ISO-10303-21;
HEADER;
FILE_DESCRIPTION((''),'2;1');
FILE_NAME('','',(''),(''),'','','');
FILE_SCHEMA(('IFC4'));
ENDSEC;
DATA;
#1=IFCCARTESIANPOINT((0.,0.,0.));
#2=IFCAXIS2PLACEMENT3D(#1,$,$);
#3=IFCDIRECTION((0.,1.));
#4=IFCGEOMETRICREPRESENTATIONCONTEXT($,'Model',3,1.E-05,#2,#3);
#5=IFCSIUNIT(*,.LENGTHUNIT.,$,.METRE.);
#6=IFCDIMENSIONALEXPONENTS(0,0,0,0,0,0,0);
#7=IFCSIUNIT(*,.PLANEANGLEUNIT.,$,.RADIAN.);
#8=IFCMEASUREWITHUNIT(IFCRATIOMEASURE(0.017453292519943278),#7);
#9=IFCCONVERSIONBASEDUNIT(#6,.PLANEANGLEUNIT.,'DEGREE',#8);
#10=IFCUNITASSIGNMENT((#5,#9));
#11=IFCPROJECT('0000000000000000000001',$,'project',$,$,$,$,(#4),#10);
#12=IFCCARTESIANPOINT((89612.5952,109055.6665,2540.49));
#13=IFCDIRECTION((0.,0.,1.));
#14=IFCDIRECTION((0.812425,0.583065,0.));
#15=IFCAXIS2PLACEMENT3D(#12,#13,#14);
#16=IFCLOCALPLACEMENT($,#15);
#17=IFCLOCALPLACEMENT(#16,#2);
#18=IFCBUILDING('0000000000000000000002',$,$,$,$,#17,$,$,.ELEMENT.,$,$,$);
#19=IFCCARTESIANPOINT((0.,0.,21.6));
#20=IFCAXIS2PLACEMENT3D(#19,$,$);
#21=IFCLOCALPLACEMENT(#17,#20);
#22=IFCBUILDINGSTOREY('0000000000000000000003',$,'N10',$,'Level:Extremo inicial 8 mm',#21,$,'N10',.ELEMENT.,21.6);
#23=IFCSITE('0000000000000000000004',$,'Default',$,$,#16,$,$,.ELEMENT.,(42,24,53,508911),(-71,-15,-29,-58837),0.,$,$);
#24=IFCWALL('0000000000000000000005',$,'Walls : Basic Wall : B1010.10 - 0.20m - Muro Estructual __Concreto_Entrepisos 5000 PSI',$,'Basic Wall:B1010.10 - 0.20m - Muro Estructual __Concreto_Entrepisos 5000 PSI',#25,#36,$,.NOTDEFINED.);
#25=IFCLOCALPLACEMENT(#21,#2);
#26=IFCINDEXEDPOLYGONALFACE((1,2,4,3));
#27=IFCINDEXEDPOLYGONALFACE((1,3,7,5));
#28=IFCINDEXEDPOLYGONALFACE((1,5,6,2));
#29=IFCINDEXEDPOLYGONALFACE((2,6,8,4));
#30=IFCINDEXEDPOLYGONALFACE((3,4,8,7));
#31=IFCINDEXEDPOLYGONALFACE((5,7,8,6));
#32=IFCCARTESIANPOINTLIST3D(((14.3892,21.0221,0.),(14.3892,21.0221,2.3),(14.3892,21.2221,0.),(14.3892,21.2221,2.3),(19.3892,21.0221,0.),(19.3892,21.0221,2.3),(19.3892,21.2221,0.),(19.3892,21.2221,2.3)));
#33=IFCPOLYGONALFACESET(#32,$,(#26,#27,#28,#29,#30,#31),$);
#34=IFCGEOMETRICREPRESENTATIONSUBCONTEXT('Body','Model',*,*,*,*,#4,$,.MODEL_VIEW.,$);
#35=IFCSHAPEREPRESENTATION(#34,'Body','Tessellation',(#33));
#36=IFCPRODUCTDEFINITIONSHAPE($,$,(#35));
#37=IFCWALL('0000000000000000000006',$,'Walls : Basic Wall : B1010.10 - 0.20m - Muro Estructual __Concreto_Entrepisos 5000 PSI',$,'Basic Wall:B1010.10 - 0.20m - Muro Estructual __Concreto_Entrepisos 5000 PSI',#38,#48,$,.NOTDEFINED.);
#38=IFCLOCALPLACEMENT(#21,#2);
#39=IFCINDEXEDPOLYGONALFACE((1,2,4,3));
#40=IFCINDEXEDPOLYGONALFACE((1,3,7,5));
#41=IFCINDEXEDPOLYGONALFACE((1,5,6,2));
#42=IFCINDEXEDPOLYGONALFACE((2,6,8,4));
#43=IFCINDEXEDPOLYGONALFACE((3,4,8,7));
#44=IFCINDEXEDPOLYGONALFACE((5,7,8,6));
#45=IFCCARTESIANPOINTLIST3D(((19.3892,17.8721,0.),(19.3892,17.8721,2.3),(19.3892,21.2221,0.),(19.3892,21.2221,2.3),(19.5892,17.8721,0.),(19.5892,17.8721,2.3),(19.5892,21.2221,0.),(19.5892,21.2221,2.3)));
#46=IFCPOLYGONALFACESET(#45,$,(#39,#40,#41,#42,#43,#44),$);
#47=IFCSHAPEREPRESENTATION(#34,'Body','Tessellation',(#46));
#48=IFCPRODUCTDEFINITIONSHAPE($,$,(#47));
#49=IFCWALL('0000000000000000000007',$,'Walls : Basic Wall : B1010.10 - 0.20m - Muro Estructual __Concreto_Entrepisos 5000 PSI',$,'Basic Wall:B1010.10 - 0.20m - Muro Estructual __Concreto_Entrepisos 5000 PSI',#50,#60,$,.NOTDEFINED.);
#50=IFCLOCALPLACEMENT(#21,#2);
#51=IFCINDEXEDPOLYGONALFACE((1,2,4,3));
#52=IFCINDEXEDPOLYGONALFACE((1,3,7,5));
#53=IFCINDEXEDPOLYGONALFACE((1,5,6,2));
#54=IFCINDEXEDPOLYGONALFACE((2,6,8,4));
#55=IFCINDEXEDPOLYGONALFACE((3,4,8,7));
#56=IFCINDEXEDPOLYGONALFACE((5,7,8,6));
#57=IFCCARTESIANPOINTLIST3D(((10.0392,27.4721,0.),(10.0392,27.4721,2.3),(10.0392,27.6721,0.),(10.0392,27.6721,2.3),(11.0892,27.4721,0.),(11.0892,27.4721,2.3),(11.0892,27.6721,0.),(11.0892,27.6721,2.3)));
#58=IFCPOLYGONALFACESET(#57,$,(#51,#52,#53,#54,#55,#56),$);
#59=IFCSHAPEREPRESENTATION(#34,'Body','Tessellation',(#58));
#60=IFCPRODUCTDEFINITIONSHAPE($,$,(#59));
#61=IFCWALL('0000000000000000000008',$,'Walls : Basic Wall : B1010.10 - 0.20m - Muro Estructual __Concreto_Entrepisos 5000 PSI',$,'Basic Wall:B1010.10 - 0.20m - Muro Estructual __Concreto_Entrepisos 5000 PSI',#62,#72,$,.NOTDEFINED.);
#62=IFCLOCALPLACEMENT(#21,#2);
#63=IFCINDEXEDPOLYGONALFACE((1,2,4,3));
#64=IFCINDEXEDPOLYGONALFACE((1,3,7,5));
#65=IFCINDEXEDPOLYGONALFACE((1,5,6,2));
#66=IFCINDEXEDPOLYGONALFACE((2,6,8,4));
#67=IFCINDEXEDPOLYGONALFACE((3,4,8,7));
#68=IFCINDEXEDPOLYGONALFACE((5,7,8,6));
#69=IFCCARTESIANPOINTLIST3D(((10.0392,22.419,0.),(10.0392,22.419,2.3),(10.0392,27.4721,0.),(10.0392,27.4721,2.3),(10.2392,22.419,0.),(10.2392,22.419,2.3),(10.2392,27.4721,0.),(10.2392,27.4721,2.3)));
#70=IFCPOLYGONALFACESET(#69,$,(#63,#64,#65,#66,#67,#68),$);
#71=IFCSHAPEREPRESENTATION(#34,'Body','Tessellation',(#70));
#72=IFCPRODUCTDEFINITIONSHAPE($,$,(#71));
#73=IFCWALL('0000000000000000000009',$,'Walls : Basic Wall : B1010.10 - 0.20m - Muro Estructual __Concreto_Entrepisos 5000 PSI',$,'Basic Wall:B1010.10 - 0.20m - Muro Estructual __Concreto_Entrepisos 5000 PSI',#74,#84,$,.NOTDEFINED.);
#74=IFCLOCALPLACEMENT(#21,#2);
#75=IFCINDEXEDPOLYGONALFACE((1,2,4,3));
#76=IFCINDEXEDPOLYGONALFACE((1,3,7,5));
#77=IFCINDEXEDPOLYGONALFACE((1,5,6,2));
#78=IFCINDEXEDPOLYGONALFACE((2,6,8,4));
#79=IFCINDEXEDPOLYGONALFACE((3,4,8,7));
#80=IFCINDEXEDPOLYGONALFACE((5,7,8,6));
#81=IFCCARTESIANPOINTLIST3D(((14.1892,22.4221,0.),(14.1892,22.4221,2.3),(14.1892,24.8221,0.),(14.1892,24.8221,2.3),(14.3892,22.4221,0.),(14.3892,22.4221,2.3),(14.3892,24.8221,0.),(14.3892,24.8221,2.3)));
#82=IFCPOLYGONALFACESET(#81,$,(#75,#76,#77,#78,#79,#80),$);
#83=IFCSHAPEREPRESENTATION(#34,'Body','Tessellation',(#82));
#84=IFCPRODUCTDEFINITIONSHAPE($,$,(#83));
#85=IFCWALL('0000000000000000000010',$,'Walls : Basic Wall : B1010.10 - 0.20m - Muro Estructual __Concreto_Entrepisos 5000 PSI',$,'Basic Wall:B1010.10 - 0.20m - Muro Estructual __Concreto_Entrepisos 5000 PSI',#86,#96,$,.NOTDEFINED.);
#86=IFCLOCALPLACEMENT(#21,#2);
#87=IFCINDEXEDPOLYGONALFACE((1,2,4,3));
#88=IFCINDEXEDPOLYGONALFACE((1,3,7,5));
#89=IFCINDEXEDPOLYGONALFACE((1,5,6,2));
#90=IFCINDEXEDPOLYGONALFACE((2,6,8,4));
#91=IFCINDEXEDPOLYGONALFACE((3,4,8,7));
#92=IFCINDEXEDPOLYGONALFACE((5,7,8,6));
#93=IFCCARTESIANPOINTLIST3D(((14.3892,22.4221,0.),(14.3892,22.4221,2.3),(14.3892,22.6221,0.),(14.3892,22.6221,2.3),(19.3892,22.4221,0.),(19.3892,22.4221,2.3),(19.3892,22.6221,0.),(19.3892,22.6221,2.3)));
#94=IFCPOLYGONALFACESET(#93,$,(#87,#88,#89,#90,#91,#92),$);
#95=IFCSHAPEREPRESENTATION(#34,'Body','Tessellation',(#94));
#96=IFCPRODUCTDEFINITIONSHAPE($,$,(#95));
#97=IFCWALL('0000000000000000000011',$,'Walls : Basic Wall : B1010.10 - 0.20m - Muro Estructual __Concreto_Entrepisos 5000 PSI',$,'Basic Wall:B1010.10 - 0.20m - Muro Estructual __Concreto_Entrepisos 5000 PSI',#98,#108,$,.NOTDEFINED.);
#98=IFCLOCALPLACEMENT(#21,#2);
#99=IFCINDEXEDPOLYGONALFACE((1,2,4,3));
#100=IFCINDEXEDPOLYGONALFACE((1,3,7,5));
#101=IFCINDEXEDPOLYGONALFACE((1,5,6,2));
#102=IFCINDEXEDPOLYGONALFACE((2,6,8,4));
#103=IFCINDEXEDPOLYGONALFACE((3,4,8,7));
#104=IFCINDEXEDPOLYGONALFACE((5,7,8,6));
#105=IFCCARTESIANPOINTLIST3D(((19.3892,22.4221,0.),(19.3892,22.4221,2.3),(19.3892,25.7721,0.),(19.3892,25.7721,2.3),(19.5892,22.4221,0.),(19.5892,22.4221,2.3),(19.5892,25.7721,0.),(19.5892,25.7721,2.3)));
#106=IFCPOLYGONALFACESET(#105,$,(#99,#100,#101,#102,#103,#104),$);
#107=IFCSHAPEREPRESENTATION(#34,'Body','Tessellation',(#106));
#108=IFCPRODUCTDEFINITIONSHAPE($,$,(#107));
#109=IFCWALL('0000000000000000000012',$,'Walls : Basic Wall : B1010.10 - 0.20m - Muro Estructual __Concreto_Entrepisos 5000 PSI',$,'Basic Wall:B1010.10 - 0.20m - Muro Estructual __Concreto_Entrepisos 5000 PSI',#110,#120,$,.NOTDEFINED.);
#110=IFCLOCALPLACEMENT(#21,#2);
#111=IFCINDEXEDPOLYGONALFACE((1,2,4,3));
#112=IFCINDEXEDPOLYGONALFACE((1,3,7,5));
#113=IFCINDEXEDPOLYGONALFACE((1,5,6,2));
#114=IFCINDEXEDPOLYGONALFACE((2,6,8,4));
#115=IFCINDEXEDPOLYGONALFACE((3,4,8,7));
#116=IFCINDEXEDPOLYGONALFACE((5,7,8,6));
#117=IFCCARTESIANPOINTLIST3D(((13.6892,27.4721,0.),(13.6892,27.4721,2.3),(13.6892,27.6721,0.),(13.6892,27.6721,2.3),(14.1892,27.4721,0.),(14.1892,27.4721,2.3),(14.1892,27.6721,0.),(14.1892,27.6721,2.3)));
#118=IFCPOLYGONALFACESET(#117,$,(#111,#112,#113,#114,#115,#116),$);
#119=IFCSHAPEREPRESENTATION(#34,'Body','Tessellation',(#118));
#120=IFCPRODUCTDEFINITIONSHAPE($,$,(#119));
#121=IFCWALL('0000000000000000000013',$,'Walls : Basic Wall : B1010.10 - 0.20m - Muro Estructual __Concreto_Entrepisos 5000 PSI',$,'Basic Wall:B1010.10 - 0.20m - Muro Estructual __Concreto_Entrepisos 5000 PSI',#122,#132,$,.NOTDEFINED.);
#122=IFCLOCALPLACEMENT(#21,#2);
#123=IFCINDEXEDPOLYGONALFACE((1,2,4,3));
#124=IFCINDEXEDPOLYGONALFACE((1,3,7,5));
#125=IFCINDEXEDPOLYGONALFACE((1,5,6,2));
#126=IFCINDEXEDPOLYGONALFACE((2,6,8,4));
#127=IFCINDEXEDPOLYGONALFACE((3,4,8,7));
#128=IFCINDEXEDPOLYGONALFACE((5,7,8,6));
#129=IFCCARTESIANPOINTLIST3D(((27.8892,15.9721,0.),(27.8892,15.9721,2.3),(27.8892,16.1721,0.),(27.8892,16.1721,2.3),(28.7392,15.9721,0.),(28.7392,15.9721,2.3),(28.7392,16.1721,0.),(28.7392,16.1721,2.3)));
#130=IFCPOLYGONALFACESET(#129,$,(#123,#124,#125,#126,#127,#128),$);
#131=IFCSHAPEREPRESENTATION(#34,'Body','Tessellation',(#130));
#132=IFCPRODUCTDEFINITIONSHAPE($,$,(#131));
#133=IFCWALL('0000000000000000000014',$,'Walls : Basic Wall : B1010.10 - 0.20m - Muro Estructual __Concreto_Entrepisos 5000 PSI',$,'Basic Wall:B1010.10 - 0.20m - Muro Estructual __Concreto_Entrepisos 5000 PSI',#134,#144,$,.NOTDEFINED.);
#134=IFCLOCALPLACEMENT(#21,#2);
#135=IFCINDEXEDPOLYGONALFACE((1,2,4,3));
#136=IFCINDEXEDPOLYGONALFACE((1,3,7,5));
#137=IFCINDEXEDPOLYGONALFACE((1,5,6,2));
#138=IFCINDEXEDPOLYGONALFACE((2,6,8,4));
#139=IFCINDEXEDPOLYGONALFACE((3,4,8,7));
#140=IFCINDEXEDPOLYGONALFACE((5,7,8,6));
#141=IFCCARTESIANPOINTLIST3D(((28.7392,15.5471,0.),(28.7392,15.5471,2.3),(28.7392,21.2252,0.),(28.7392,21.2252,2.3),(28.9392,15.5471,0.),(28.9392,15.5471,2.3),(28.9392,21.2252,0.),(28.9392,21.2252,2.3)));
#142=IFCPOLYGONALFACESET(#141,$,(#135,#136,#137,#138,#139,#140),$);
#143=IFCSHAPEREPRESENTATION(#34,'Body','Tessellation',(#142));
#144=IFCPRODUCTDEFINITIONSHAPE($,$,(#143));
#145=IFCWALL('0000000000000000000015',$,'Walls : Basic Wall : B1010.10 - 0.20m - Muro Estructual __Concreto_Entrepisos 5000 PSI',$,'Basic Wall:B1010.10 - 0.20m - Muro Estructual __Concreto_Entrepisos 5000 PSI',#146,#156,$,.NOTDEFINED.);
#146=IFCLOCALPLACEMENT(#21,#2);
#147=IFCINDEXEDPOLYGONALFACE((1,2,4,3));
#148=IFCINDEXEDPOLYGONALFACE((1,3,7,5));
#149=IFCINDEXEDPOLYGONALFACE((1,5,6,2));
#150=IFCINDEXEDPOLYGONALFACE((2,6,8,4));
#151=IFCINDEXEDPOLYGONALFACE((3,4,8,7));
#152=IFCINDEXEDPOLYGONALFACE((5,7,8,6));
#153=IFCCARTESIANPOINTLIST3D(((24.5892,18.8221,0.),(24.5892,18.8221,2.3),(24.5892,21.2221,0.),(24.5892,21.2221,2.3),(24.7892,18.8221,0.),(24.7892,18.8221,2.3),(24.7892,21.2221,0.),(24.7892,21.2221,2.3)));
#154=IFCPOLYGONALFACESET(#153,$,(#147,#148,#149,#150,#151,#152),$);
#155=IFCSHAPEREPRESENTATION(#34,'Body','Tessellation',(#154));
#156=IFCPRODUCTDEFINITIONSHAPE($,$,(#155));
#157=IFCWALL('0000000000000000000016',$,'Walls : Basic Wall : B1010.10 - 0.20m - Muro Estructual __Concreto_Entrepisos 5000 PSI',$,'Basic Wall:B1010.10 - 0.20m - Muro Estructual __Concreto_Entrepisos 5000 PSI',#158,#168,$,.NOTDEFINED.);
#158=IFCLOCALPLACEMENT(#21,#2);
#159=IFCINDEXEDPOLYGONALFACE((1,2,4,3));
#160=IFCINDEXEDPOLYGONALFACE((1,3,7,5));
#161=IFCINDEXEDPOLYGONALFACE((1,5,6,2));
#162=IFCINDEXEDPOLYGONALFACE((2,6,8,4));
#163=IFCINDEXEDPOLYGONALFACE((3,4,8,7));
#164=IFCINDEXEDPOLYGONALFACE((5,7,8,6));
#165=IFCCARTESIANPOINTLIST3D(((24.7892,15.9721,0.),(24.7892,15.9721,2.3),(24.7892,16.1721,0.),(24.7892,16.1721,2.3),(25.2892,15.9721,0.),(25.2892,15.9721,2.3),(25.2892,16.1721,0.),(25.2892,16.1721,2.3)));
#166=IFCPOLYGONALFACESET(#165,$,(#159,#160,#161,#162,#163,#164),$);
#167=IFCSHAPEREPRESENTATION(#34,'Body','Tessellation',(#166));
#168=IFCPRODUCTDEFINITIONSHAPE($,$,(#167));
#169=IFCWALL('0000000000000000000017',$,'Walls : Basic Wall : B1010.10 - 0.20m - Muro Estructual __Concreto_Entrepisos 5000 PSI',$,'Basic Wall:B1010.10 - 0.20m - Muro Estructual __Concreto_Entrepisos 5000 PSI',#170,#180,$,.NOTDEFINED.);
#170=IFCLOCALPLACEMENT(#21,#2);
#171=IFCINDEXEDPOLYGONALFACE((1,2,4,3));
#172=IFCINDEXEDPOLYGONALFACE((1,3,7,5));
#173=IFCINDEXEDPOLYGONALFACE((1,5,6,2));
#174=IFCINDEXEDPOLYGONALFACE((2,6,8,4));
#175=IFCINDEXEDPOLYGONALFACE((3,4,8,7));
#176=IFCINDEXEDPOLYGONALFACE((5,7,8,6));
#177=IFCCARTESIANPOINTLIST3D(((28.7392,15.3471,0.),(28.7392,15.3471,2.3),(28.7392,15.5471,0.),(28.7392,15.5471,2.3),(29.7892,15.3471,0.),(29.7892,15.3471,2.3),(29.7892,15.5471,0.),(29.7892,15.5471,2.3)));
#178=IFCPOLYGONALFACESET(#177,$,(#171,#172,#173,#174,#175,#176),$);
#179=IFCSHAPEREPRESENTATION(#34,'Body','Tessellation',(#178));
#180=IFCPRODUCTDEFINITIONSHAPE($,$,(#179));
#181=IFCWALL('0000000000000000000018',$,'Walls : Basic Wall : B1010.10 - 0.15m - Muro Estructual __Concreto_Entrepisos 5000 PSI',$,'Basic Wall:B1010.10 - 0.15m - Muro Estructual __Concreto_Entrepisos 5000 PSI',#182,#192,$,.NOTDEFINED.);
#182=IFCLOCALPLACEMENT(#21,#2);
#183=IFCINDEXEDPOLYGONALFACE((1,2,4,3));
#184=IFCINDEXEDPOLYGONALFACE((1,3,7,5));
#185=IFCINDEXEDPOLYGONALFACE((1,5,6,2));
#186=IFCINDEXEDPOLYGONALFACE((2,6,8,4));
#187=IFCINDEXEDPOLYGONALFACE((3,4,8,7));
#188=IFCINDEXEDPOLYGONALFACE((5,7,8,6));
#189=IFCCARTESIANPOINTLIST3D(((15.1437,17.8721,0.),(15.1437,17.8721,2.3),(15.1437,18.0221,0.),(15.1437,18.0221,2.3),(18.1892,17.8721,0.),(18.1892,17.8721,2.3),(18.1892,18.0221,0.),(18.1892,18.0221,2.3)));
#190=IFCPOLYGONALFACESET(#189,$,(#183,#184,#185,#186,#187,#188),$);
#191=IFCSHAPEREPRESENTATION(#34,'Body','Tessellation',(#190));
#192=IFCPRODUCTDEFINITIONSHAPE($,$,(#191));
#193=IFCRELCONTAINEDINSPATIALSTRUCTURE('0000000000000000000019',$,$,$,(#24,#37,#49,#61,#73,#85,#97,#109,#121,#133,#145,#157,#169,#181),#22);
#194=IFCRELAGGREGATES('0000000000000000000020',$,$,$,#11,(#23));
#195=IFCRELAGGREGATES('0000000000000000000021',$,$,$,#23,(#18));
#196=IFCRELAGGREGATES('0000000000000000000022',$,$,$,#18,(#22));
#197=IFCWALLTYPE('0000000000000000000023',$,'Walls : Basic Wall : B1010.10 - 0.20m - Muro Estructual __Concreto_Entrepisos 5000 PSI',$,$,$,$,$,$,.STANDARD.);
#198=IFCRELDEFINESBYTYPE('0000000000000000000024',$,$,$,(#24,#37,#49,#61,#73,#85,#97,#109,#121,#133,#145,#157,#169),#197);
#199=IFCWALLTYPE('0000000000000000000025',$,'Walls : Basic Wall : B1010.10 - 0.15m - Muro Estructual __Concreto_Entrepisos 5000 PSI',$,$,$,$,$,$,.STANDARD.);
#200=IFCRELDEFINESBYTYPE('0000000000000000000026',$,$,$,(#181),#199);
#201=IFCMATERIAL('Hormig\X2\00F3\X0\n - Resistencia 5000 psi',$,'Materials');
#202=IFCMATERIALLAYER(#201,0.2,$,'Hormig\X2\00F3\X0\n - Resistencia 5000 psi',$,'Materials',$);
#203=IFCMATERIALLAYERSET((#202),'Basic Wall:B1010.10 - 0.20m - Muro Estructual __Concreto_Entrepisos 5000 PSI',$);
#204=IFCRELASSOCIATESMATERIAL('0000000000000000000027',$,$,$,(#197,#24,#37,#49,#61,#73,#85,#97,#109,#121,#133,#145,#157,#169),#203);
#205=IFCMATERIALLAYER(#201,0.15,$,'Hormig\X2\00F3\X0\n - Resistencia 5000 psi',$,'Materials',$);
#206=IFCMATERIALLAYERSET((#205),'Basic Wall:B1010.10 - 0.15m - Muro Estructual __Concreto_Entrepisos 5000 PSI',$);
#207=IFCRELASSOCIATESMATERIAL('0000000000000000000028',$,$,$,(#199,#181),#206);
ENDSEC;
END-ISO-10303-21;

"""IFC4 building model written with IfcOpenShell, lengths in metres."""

from ifc_helpers import new_model, entity, si_unit, converted_unit, direction, frame, frame_2d, origin, place, context, subcontext, project, spatial, rectangle, extrude, material, layer, layer_set, layer_usage, type_object, element, save


model = new_model("IFC4")

# Units and contexts
model_context = context("Model", 3, precision=1e-05, world=origin(), true_north=direction((0.0, 1.0)))
body_context = subcontext(model_context, "Body", "Model", "MODEL_VIEW")
ifc_project = project(units=[si_unit("LENGTHUNIT", "METRE"), converted_unit("PLANEANGLEUNIT", "DEGREE", entity("IfcRatioMeasure", 0.017453292519943278), si_unit("PLANEANGLEUNIT", "RADIAN"), dimensions=[0, 0, 0, 0, 0, 0, 0])], contexts=[model_context])

# Site, building, storey
site_placement = place(None, frame((89612.5952, 109055.6665, 2540.49), z_axis=(0.0, 0.0, 1.0), x_axis=(0.812425, 0.583065, 0.0)))
site = spatial("IfcSite", under=ifc_project, at=site_placement, Name="Default", CompositionType="ELEMENT", RefLatitude=(42, 24, 53, 508911), RefLongitude=(-71, -15, -29, -58837), RefElevation=0.0)
building_placement = place(site_placement, origin())
building = spatial("IfcBuilding", under=site, at=building_placement, CompositionType="ELEMENT")
storey_placement = place(building_placement, frame((0.0, 0.0, 21.6)))
storey = spatial("IfcBuildingStorey", under=building, at=storey_placement, Name="N10", ObjectType="Level:Extremo inicial 8 mm", LongName="N10", CompositionType="ELEMENT", Elevation=21.6)

# Walls
ifc_material = material(Name="Hormigón - Resistencia 5000 psi", Category="Materials")
ifc_layer_1 = layer(ifc_material, 0.2, Name="Hormigón - Resistencia 5000 psi", Category="Materials")
ifc_layer_set_1 = layer_set([ifc_layer_1], Name="Basic Wall:B1010.10 - 0.20m - Muro Estructual __Concreto_Entrepisos 5000 PSI")
ifc_layer_usage_1 = layer_usage(ifc_layer_set_1, "AXIS2", "NEGATIVE", 0.1)
wall_type_1 = type_object("IfcWallType", Name="Walls : Basic Wall : B1010.10 - 0.20m - Muro Estructual __Concreto_Entrepisos 5000 PSI", PredefinedType="STANDARD", material=ifc_layer_set_1)
wall_1_placement = place(storey_placement, frame((14.3892, 21.1221, 0.0)))
element("IfcWall", 1, at=wall_1_placement, inside=storey, type_object=wall_type_1, material=ifc_layer_usage_1, Name="Walls : Basic Wall : B1010.10 - 0.20m - Muro Estructual __Concreto_Entrepisos 5000 PSI", ObjectType="Basic Wall:B1010.10 - 0.20m - Muro Estructual __Concreto_Entrepisos 5000 PSI", PredefinedType="NOTDEFINED", context=body_context, shape_type="SweptSolid", body=[
    extrude(rectangle(XDim=5.0, YDim=0.2, at=frame_2d((2.5, 0.0), x_axis=(-1.0, 0.0))), origin(), (0.0, 0.0, 1.0), 2.3),
])
ifc_layer_usage_2 = layer_usage(ifc_layer_set_1, "AXIS2", "NEGATIVE", 0.1)
wall_2_placement = place(storey_placement, frame((19.4892, 21.2221, 0.0), z_axis=(0.0, 0.0, 1.0), x_axis=(0.0, -1.0, 0.0)))
element("IfcWall", 2, at=wall_2_placement, inside=storey, type_object=wall_type_1, material=ifc_layer_usage_2, Name="Walls : Basic Wall : B1010.10 - 0.20m - Muro Estructual __Concreto_Entrepisos 5000 PSI", ObjectType="Basic Wall:B1010.10 - 0.20m - Muro Estructual __Concreto_Entrepisos 5000 PSI", PredefinedType="NOTDEFINED", context=body_context, shape_type="SweptSolid", body=[
    extrude(rectangle(XDim=3.35, YDim=0.2, at=frame_2d((1.675, 0.0), x_axis=(-1.0, 0.0))), origin(), (0.0, 0.0, 1.0), 2.3),
])
ifc_layer_usage_3 = layer_usage(ifc_layer_set_1, "AXIS2", "POSITIVE", -0.1)
wall_3_placement = place(storey_placement, frame((11.0892, 27.5721, 0.0), z_axis=(0.0, 0.0, 1.0), x_axis=(-1.0, 0.0, 0.0)))
element("IfcWall", 3, at=wall_3_placement, inside=storey, type_object=wall_type_1, material=ifc_layer_usage_3, Name="Walls : Basic Wall : B1010.10 - 0.20m - Muro Estructual __Concreto_Entrepisos 5000 PSI", ObjectType="Basic Wall:B1010.10 - 0.20m - Muro Estructual __Concreto_Entrepisos 5000 PSI", PredefinedType="NOTDEFINED", context=body_context, shape_type="SweptSolid", body=[
    extrude(rectangle(XDim=1.05, YDim=0.2, at=frame_2d((0.525, 0.0), x_axis=(-1.0, 0.0))), origin(), (0.0, 0.0, 1.0), 2.3),
])
ifc_layer_usage_4 = layer_usage(ifc_layer_set_1, "AXIS2", "POSITIVE", -0.1)
wall_4_placement = place(storey_placement, frame((10.1392, 27.4721, 0.0), z_axis=(0.0, 0.0, 1.0), x_axis=(0.0, -1.0, 0.0)))
element("IfcWall", 4, at=wall_4_placement, inside=storey, type_object=wall_type_1, material=ifc_layer_usage_4, Name="Walls : Basic Wall : B1010.10 - 0.20m - Muro Estructual __Concreto_Entrepisos 5000 PSI", ObjectType="Basic Wall:B1010.10 - 0.20m - Muro Estructual __Concreto_Entrepisos 5000 PSI", PredefinedType="NOTDEFINED", context=body_context, shape_type="SweptSolid", body=[
    extrude(rectangle(XDim=5.0531, YDim=0.2, at=frame_2d((2.5265, 0.0), x_axis=(-1.0, 0.0))), origin(), (0.0, 0.0, 1.0), 2.3),
])
ifc_layer_usage_5 = layer_usage(ifc_layer_set_1, "AXIS2", "POSITIVE", -0.1)
wall_5_placement = place(storey_placement, frame((14.2892, 24.8221, 0.0), z_axis=(0.0, 0.0, 1.0), x_axis=(0.0, -1.0, 0.0)))
element("IfcWall", 5, at=wall_5_placement, inside=storey, type_object=wall_type_1, material=ifc_layer_usage_5, Name="Walls : Basic Wall : B1010.10 - 0.20m - Muro Estructual __Concreto_Entrepisos 5000 PSI", ObjectType="Basic Wall:B1010.10 - 0.20m - Muro Estructual __Concreto_Entrepisos 5000 PSI", PredefinedType="NOTDEFINED", context=body_context, shape_type="SweptSolid", body=[
    extrude(rectangle(XDim=2.4, YDim=0.2, at=frame_2d((1.2, 0.0), x_axis=(-1.0, 0.0))), origin(), (0.0, 0.0, 1.0), 2.3),
])
ifc_layer_usage_6 = layer_usage(ifc_layer_set_1, "AXIS2", "POSITIVE", -0.1)
wall_6_placement = place(storey_placement, frame((14.3892, 22.5221, 0.0)))
element("IfcWall", 6, at=wall_6_placement, inside=storey, type_object=wall_type_1, material=ifc_layer_usage_6, Name="Walls : Basic Wall : B1010.10 - 0.20m - Muro Estructual __Concreto_Entrepisos 5000 PSI", ObjectType="Basic Wall:B1010.10 - 0.20m - Muro Estructual __Concreto_Entrepisos 5000 PSI", PredefinedType="NOTDEFINED", context=body_context, shape_type="SweptSolid", body=[
    extrude(rectangle(XDim=5.0, YDim=0.2, at=frame_2d((2.5, 0.0), x_axis=(-1.0, 0.0))), origin(), (0.0, 0.0, 1.0), 2.3),
])
ifc_layer_usage_7 = layer_usage(ifc_layer_set_1, "AXIS2", "POSITIVE", -0.1)
wall_7_placement = place(storey_placement, frame((19.4892, 22.4221, 0.0), z_axis=(0.0, 0.0, 1.0), x_axis=(0.0, 1.0, 0.0)))
element("IfcWall", 7, at=wall_7_placement, inside=storey, type_object=wall_type_1, material=ifc_layer_usage_7, Name="Walls : Basic Wall : B1010.10 - 0.20m - Muro Estructual __Concreto_Entrepisos 5000 PSI", ObjectType="Basic Wall:B1010.10 - 0.20m - Muro Estructual __Concreto_Entrepisos 5000 PSI", PredefinedType="NOTDEFINED", context=body_context, shape_type="SweptSolid", body=[
    extrude(rectangle(XDim=3.35, YDim=0.2, at=frame_2d((1.675, 0.0), x_axis=(-1.0, 0.0))), origin(), (0.0, 0.0, 1.0), 2.3),
])
ifc_layer_usage_8 = layer_usage(ifc_layer_set_1, "AXIS2", "POSITIVE", -0.1)
wall_8_placement = place(storey_placement, frame((13.6892, 27.5721, 0.0)))
element("IfcWall", 8, at=wall_8_placement, inside=storey, type_object=wall_type_1, material=ifc_layer_usage_8, Name="Walls : Basic Wall : B1010.10 - 0.20m - Muro Estructual __Concreto_Entrepisos 5000 PSI", ObjectType="Basic Wall:B1010.10 - 0.20m - Muro Estructual __Concreto_Entrepisos 5000 PSI", PredefinedType="NOTDEFINED", context=body_context, shape_type="SweptSolid", body=[
    extrude(rectangle(XDim=0.5, YDim=0.2, at=frame_2d((0.25, 0.0), x_axis=(-1.0, 0.0))), origin(), (0.0, 0.0, 1.0), 2.3),
])
ifc_layer_usage_9 = layer_usage(ifc_layer_set_1, "AXIS2", "POSITIVE", -0.1)
wall_9_placement = place(storey_placement, frame((27.8892, 16.0721, 0.0)))
element("IfcWall", 9, at=wall_9_placement, inside=storey, type_object=wall_type_1, material=ifc_layer_usage_9, Name="Walls : Basic Wall : B1010.10 - 0.20m - Muro Estructual __Concreto_Entrepisos 5000 PSI", ObjectType="Basic Wall:B1010.10 - 0.20m - Muro Estructual __Concreto_Entrepisos 5000 PSI", PredefinedType="NOTDEFINED", context=body_context, shape_type="SweptSolid", body=[
    extrude(rectangle(XDim=0.85, YDim=0.2, at=frame_2d((0.425, 0.0), x_axis=(-1.0, 0.0))), origin(), (0.0, 0.0, 1.0), 2.3),
])
ifc_layer_usage_10 = layer_usage(ifc_layer_set_1, "AXIS2", "POSITIVE", -0.1)
wall_10_placement = place(storey_placement, frame((28.8392, 15.5471, 0.0), z_axis=(0.0, 0.0, 1.0), x_axis=(0.0, 1.0, 0.0)))
element("IfcWall", 10, at=wall_10_placement, inside=storey, type_object=wall_type_1, material=ifc_layer_usage_10, Name="Walls : Basic Wall : B1010.10 - 0.20m - Muro Estructual __Concreto_Entrepisos 5000 PSI", ObjectType="Basic Wall:B1010.10 - 0.20m - Muro Estructual __Concreto_Entrepisos 5000 PSI", PredefinedType="NOTDEFINED", context=body_context, shape_type="SweptSolid", body=[
    extrude(rectangle(XDim=5.6781, YDim=0.2, at=frame_2d((2.839, 0.0), x_axis=(-1.0, 0.0))), origin(), (0.0, 0.0, 1.0), 2.3),
])
ifc_layer_usage_11 = layer_usage(ifc_layer_set_1, "AXIS2", "POSITIVE", -0.1)
wall_11_placement = place(storey_placement, frame((24.6892, 18.8221, 0.0), z_axis=(0.0, 0.0, 1.0), x_axis=(0.0, 1.0, 0.0)))
element("IfcWall", 11, at=wall_11_placement, inside=storey, type_object=wall_type_1, material=ifc_layer_usage_11, Name="Walls : Basic Wall : B1010.10 - 0.20m - Muro Estructual __Concreto_Entrepisos 5000 PSI", ObjectType="Basic Wall:B1010.10 - 0.20m - Muro Estructual __Concreto_Entrepisos 5000 PSI", PredefinedType="NOTDEFINED", context=body_context, shape_type="SweptSolid", body=[
    extrude(rectangle(XDim=2.4, YDim=0.2, at=frame_2d((1.2, 0.0), x_axis=(-1.0, 0.0))), origin(), (0.0, 0.0, 1.0), 2.3),
])
ifc_layer_usage_12 = layer_usage(ifc_layer_set_1, "AXIS2", "POSITIVE", -0.1)
wall_12_placement = place(storey_placement, frame((25.2892, 16.0721, 0.0), z_axis=(0.0, 0.0, 1.0), x_axis=(-1.0, 0.0, 0.0)))
element("IfcWall", 12, at=wall_12_placement, inside=storey, type_object=wall_type_1, material=ifc_layer_usage_12, Name="Walls : Basic Wall : B1010.10 - 0.20m - Muro Estructual __Concreto_Entrepisos 5000 PSI", ObjectType="Basic Wall:B1010.10 - 0.20m - Muro Estructual __Concreto_Entrepisos 5000 PSI", PredefinedType="NOTDEFINED", context=body_context, shape_type="SweptSolid", body=[
    extrude(rectangle(XDim=0.5, YDim=0.2, at=frame_2d((0.25, 0.0), x_axis=(-1.0, 0.0))), origin(), (0.0, 0.0, 1.0), 2.3),
])
ifc_layer_usage_13 = layer_usage(ifc_layer_set_1, "AXIS2", "NEGATIVE", 0.1)
wall_13_placement = place(storey_placement, frame((29.7892, 15.4471, 0.0), z_axis=(0.0, 0.0, 1.0), x_axis=(-1.0, 0.0, 0.0)))
element("IfcWall", 13, at=wall_13_placement, inside=storey, type_object=wall_type_1, material=ifc_layer_usage_13, Name="Walls : Basic Wall : B1010.10 - 0.20m - Muro Estructual __Concreto_Entrepisos 5000 PSI", ObjectType="Basic Wall:B1010.10 - 0.20m - Muro Estructual __Concreto_Entrepisos 5000 PSI", PredefinedType="NOTDEFINED", context=body_context, shape_type="SweptSolid", body=[
    extrude(rectangle(XDim=1.05, YDim=0.2, at=frame_2d((0.525, 0.0), x_axis=(-1.0, 0.0))), origin(), (0.0, 0.0, 1.0), 2.3),
])
ifc_layer_2 = layer(ifc_material, 0.15, Name="Hormigón - Resistencia 5000 psi", Category="Materials")
ifc_layer_set_2 = layer_set([ifc_layer_2], Name="Basic Wall:B1010.10 - 0.15m - Muro Estructual __Concreto_Entrepisos 5000 PSI")
ifc_layer_usage_14 = layer_usage(ifc_layer_set_2, "AXIS2", "NEGATIVE", 0.075)
wall_type_2 = type_object("IfcWallType", Name="Walls : Basic Wall : B1010.10 - 0.15m - Muro Estructual __Concreto_Entrepisos 5000 PSI", PredefinedType="STANDARD", material=ifc_layer_set_2)
wall_14_placement = place(storey_placement, frame((18.1892, 17.9471, 0.0), z_axis=(0.0, 0.0, 1.0), x_axis=(-1.0, 0.0, 0.0)))
element("IfcWall", 14, at=wall_14_placement, inside=storey, type_object=wall_type_2, material=ifc_layer_usage_14, Name="Walls : Basic Wall : B1010.10 - 0.15m - Muro Estructual __Concreto_Entrepisos 5000 PSI", ObjectType="Basic Wall:B1010.10 - 0.15m - Muro Estructual __Concreto_Entrepisos 5000 PSI", PredefinedType="NOTDEFINED", context=body_context, shape_type="SweptSolid", body=[
    extrude(rectangle(XDim=3.0455, YDim=0.15, at=frame_2d((1.5228, 0.0), x_axis=(-1.0, 0.0))), origin(), (0.0, 0.0, 1.0), 2.3),
])

save(model, "model.ifc")
